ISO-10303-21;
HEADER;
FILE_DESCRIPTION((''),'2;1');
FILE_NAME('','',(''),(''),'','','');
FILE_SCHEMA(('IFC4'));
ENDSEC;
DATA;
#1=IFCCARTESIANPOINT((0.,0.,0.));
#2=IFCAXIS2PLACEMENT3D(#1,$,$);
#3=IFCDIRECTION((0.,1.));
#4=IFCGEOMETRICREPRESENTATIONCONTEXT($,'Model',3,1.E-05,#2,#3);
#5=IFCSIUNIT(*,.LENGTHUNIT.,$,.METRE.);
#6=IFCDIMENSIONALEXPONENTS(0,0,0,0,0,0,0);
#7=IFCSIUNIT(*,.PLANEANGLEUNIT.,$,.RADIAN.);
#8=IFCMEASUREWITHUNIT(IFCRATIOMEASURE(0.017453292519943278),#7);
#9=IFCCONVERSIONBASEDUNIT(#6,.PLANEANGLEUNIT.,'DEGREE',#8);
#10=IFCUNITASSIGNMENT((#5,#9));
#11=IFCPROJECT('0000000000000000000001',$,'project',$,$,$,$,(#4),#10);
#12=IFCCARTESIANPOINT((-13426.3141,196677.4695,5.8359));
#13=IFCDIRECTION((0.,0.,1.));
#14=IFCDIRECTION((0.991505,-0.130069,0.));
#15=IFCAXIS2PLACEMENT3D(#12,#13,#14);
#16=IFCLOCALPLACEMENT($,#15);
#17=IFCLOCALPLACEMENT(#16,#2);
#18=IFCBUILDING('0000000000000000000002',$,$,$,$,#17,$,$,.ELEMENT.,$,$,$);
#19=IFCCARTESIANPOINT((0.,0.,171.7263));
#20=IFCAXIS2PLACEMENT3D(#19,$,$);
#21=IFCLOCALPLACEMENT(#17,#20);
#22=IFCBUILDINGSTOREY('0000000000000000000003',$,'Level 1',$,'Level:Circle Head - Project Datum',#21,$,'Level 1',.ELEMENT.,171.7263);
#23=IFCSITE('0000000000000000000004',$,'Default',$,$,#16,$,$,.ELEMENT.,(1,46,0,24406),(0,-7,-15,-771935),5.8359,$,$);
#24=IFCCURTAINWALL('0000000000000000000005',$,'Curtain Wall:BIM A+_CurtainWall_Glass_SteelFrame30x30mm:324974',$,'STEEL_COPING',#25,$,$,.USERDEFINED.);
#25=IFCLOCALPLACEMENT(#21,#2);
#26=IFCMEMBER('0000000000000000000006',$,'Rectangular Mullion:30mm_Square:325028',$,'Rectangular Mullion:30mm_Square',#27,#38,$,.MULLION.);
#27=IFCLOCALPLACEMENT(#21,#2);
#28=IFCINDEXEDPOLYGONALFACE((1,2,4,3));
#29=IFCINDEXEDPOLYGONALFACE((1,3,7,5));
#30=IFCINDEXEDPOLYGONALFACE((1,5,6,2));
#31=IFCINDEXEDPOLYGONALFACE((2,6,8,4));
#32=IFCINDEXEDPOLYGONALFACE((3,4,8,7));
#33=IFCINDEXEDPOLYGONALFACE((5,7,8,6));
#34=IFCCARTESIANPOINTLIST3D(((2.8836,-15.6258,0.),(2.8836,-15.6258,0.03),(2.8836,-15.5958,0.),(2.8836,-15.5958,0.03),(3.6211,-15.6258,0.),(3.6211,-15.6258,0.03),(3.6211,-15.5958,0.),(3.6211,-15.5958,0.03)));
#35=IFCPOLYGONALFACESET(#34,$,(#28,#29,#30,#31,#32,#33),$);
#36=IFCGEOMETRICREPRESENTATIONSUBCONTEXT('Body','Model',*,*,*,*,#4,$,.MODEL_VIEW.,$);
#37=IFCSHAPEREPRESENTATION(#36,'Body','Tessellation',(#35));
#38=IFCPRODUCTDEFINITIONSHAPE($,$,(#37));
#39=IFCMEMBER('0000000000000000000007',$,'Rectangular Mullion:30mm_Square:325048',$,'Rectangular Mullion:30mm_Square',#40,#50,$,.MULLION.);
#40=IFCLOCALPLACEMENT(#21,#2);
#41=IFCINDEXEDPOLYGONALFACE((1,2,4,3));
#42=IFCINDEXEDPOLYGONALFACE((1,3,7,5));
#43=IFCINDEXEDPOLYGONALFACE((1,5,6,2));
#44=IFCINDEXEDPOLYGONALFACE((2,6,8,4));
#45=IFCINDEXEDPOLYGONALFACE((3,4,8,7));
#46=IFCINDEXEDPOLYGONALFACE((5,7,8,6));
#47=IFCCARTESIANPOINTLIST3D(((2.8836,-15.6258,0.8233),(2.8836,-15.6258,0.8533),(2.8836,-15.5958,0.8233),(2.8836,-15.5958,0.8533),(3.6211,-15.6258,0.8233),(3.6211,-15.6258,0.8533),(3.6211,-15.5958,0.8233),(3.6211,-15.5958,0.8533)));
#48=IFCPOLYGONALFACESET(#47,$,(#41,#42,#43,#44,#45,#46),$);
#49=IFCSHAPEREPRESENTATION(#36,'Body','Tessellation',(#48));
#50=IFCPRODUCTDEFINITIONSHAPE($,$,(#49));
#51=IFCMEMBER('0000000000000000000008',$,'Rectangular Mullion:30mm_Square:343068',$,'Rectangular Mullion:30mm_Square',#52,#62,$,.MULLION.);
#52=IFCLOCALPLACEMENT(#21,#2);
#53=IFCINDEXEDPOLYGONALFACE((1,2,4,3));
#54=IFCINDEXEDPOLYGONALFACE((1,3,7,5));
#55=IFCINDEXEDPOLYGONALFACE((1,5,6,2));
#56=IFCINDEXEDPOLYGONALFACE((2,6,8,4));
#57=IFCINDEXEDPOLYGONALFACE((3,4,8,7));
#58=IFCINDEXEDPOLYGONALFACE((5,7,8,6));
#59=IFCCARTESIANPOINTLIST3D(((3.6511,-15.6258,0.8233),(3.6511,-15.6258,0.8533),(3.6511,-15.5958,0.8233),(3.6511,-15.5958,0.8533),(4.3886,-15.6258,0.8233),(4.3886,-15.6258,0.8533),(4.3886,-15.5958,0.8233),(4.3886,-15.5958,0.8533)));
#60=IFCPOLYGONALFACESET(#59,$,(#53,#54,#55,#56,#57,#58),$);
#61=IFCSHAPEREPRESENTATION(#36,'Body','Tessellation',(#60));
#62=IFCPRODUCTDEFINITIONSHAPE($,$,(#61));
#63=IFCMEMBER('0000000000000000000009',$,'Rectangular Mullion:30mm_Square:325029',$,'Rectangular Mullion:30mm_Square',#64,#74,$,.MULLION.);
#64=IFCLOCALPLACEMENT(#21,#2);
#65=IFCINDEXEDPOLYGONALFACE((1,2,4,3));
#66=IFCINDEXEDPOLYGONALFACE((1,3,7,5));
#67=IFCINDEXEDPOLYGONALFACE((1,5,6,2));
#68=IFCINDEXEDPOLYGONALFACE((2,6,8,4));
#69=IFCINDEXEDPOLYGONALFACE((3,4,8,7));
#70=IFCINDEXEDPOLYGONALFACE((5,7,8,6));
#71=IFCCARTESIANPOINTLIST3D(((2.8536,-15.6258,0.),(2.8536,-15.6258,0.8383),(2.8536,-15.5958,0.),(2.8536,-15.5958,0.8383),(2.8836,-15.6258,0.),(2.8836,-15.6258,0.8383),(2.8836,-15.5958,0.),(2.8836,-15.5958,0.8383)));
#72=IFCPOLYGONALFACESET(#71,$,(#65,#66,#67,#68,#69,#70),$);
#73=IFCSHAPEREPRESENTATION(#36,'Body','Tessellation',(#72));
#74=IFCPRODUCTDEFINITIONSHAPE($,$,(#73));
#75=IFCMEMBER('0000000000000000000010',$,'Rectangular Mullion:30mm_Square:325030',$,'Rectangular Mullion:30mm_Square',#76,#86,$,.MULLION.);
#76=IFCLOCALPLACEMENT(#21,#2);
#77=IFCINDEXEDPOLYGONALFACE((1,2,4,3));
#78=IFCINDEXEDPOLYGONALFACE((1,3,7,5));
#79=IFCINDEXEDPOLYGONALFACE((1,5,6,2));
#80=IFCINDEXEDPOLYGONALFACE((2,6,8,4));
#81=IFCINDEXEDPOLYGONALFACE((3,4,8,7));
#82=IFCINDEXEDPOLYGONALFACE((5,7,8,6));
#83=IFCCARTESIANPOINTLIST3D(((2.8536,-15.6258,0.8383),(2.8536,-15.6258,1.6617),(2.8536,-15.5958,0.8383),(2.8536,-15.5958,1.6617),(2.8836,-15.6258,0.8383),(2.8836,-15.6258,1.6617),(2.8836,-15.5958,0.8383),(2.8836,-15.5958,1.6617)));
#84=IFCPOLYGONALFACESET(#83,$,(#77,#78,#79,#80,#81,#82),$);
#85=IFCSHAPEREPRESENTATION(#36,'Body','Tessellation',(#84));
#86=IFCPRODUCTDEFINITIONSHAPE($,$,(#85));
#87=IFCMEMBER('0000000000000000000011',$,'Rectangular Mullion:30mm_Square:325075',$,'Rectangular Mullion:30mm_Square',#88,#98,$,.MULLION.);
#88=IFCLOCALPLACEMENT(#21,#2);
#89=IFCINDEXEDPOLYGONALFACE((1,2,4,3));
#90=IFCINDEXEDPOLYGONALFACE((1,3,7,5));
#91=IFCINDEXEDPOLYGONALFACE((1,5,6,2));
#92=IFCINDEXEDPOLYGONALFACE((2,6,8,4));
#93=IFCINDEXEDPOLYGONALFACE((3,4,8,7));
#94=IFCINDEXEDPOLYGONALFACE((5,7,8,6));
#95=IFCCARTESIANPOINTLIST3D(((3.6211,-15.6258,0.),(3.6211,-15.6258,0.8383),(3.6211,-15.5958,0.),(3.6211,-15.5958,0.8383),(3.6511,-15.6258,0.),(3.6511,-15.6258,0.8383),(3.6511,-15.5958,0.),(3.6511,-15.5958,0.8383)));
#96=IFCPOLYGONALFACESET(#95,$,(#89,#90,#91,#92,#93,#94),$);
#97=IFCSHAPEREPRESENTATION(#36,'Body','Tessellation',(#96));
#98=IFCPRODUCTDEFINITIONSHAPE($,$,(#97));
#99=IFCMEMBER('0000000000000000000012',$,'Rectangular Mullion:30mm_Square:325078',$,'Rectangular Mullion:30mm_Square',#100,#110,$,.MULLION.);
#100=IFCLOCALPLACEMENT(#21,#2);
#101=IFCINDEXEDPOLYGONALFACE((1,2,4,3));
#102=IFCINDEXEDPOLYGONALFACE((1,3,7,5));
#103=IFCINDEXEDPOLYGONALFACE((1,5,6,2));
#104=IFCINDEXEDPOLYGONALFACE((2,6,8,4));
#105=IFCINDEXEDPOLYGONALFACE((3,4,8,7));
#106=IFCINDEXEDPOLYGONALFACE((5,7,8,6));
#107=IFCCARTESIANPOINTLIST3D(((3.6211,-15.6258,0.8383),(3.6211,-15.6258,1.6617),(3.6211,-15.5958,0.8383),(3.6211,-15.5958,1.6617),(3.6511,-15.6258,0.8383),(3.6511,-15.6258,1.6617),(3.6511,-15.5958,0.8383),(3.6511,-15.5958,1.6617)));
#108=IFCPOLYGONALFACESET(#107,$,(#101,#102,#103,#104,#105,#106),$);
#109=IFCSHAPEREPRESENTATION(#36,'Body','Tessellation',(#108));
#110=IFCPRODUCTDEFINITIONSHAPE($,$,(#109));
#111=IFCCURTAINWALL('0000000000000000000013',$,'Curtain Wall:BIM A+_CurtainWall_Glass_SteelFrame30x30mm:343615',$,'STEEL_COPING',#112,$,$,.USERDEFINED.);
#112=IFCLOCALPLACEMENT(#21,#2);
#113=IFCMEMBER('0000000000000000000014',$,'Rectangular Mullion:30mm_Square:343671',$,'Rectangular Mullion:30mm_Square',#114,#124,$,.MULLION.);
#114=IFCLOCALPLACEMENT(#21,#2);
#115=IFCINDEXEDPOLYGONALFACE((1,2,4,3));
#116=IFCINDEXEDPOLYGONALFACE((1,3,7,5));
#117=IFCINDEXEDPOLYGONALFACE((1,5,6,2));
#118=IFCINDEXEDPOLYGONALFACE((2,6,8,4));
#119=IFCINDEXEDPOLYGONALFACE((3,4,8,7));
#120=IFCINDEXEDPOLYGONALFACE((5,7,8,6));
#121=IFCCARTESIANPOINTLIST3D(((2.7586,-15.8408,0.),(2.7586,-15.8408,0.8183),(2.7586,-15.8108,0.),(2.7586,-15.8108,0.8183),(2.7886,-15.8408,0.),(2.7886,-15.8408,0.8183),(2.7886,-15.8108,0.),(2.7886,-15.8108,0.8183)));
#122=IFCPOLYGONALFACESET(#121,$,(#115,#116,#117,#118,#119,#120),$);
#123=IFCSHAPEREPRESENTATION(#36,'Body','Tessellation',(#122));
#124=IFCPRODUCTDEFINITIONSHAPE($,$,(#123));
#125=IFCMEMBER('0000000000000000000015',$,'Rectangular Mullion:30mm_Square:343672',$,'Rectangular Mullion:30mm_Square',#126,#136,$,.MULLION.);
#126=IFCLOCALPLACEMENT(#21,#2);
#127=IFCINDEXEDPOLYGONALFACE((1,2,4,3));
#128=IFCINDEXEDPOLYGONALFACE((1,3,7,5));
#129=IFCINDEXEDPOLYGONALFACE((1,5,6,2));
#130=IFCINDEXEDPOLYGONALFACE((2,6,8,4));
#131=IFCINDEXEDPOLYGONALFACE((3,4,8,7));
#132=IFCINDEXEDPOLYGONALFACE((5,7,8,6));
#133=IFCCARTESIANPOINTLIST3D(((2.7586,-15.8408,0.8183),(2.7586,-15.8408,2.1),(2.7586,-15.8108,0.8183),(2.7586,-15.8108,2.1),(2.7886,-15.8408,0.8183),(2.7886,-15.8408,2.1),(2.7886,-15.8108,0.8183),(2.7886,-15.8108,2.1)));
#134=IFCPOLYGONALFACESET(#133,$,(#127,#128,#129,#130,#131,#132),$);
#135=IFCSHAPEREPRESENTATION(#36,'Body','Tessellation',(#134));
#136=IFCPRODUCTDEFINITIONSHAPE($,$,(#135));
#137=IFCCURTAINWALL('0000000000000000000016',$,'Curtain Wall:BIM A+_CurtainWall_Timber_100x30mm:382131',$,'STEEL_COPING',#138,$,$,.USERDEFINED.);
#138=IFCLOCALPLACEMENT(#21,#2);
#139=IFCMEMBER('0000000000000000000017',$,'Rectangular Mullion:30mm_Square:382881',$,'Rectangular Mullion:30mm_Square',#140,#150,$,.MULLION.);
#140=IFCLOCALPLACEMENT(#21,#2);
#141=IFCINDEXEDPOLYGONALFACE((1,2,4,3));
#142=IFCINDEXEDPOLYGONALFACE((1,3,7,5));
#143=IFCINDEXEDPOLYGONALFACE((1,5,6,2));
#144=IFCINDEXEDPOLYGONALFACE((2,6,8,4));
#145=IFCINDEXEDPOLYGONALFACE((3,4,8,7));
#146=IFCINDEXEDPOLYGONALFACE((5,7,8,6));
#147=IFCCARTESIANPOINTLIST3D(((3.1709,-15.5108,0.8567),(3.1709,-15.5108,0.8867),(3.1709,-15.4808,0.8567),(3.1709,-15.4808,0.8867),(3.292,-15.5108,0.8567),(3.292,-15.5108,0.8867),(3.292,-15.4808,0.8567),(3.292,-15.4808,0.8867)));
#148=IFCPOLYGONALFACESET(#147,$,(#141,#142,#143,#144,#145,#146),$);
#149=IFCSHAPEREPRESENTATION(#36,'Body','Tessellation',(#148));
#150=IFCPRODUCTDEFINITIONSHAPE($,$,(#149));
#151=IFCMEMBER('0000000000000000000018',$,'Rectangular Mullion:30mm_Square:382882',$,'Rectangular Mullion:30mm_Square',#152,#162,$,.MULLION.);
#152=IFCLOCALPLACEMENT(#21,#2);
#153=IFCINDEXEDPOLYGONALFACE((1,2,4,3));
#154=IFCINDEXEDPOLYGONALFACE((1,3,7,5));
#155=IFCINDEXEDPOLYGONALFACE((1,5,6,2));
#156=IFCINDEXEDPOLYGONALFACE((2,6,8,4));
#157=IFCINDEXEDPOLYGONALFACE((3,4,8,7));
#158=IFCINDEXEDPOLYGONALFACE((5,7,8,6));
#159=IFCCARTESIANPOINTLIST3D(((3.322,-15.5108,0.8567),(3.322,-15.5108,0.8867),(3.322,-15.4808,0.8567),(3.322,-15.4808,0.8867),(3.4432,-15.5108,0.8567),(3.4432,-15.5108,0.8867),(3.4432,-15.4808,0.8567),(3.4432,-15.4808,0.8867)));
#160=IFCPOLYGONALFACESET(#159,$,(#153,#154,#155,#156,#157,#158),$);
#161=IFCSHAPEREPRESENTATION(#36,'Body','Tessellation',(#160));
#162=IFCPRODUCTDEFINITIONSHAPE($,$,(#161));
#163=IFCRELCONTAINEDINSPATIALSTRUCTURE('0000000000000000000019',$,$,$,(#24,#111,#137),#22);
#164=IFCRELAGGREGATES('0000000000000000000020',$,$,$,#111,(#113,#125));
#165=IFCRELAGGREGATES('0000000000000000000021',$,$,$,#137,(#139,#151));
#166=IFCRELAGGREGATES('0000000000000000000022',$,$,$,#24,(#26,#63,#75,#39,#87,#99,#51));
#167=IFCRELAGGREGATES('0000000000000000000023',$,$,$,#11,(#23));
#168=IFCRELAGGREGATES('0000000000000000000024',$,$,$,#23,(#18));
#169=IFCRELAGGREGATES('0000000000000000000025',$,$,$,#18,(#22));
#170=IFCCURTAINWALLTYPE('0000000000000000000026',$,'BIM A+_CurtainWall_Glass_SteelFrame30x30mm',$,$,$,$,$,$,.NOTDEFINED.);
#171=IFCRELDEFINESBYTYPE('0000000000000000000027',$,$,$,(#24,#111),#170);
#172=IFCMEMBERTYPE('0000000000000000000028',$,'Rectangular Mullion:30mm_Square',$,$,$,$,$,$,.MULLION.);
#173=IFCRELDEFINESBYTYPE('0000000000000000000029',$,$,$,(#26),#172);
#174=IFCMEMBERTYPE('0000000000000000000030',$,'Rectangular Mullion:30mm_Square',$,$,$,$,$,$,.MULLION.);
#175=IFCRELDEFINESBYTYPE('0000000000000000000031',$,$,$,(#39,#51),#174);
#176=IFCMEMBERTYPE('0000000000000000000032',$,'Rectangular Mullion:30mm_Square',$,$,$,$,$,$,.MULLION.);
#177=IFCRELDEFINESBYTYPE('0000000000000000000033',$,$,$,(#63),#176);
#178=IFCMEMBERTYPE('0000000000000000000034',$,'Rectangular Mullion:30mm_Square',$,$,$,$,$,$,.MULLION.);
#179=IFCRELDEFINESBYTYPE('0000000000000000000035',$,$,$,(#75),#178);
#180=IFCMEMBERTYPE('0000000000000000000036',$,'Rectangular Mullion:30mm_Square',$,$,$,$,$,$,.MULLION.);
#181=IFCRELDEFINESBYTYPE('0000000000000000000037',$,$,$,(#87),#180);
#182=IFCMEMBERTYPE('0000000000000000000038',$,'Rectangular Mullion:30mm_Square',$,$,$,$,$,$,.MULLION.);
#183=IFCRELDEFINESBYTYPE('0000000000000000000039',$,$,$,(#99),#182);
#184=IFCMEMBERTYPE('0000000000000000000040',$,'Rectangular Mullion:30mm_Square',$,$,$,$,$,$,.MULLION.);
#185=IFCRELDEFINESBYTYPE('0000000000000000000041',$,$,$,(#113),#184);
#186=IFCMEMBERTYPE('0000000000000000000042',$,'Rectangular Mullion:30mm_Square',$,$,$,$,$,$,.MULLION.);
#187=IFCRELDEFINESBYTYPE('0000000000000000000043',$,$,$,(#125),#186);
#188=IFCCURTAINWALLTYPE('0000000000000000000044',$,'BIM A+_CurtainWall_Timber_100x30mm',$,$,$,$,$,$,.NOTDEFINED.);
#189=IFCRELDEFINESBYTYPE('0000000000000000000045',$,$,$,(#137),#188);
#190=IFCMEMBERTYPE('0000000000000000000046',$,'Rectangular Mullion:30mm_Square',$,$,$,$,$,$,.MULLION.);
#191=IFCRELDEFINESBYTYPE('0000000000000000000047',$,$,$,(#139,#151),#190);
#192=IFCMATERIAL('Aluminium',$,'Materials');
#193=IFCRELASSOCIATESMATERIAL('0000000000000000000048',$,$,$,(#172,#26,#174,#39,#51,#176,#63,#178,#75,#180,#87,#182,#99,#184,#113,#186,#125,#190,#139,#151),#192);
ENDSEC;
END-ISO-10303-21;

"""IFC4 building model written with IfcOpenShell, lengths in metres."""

from ifc_helpers import new_model, entity, si_unit, converted_unit, direction, frame, origin, place, context, subcontext, project, spatial, indexed_curve, outline, extrude, source, transform, mapped, material, type_object, type_shapes, element, aggregate, save


model = new_model("IFC4")

# Units and contexts
model_context = context("Model", 3, precision=1e-05, world=origin(), true_north=direction((0.0, 1.0)))
body_context = subcontext(model_context, "Body", "Model", "MODEL_VIEW")
ifc_project = project(units=[si_unit("LENGTHUNIT", "METRE"), converted_unit("PLANEANGLEUNIT", "DEGREE", entity("IfcRatioMeasure", 0.017453292519943278), si_unit("PLANEANGLEUNIT", "RADIAN"), dimensions=[0, 0, 0, 0, 0, 0, 0])], contexts=[model_context])

# Site, building, storey
site_placement = place(None, frame((-13426.3141, 196677.4695, 5.8359), z_axis=(0.0, 0.0, 1.0), x_axis=(0.991505, -0.130069, 0.0)))
site = spatial("IfcSite", under=ifc_project, at=site_placement, Name="Default", CompositionType="ELEMENT", RefLatitude=(1, 46, 0, 24406), RefLongitude=(0, -7, -15, -771935), RefElevation=5.8359)
building_placement = place(site_placement, origin())
building = spatial("IfcBuilding", under=site, at=building_placement, CompositionType="ELEMENT")
storey_placement = place(building_placement, frame((0.0, 0.0, 171.7263)))
storey = spatial("IfcBuildingStorey", under=building, at=storey_placement, Name="Level 1", ObjectType="Level:Circle Head - Project Datum", LongName="Level 1", CompositionType="ELEMENT", Elevation=171.7263)

# Curtain walls, members
curtain_wall_type_1 = type_object("IfcCurtainWallType", Name="BIM A+_CurtainWall_Glass_SteelFrame30x30mm", PredefinedType="NOTDEFINED")
curtain_wall_1_placement = place(storey_placement, frame((0.0, 0.0, -171.7263)))
curtain_wall_1 = element("IfcCurtainWall", 1, at=curtain_wall_1_placement, inside=storey, type_object=curtain_wall_type_1, Name="Curtain Wall:BIM A+_CurtainWall_Glass_SteelFrame30x30mm:324974", ObjectType="STEEL_COPING", PredefinedType="USERDEFINED")
ifc_material_1 = material(Name="Aluminium", Category="Materials")
member_type_1 = type_object("IfcMemberType", Name="Rectangular Mullion:30mm_Square", PredefinedType="MULLION", material=ifc_material_1)
shared_shape_1 = source(origin(), body_context, "Body", "SweptSolid", [
    extrude(outline(indexed_curve([(-0.015, -0.015), (0.015, -0.015), (0.015, 0.015), (-0.015, 0.015), (-0.015, -0.015)], self_intersect=False)), frame((-0.015, 0.0, -0.7375), z_axis=(0.0, 0.0, 1.0), x_axis=(0.0, -1.0, 0.0)), (0.0, 0.0, 1.0), 0.7375),
])
type_shapes(member_type_1, [shared_shape_1])
member_1_placement = place(curtain_wall_1_placement, frame((3.6211, -15.6108, 171.7263), z_axis=(1.0, 0.0, 0.0), x_axis=(0.0, 0.0, -1.0)))
member_1 = element("IfcMember", 2, at=member_1_placement, type_object=member_type_1, material=ifc_material_1, Name="Rectangular Mullion:30mm_Square:325028", ObjectType="Rectangular Mullion:30mm_Square", PredefinedType="MULLION", context=body_context, shape_type="MappedRepresentation", body=[
    mapped(shared_shape_1, transform((0.0, 0.0, 0.0), scale=1.0)),
])
member_type_2 = type_object("IfcMemberType", Name="Rectangular Mullion:30mm_Square", PredefinedType="MULLION", material=ifc_material_1)
shared_shape_2 = source(origin(), body_context, "Body", "SweptSolid", [
    extrude(outline(indexed_curve([(-0.015, -0.015), (0.015, -0.015), (0.015, 0.015), (-0.015, 0.015), (-0.015, -0.015)], self_intersect=False)), frame((0.0, 0.0, -0.7375), z_axis=(0.0, 0.0, 1.0), x_axis=(0.0, -1.0, 0.0)), (0.0, 0.0, 1.0), 0.7375),
])
type_shapes(member_type_2, [shared_shape_2])
member_2_placement = place(curtain_wall_1_placement, frame((2.8836, -15.6108, 172.5646), z_axis=(-1.0, 0.0, 0.0), x_axis=(0.0, 0.0, 1.0)))
member_2 = element("IfcMember", 3, at=member_2_placement, type_object=member_type_2, material=ifc_material_1, Name="Rectangular Mullion:30mm_Square:325048", ObjectType="Rectangular Mullion:30mm_Square", PredefinedType="MULLION", context=body_context, shape_type="MappedRepresentation", body=[
    mapped(shared_shape_2, transform((0.0, 0.0, 0.0), scale=1.0)),
])
member_3_placement = place(curtain_wall_1_placement, frame((3.6511, -15.6108, 172.5646), z_axis=(-1.0, 0.0, 0.0), x_axis=(0.0, 0.0, 1.0)))
member_3 = element("IfcMember", 4, at=member_3_placement, type_object=member_type_2, material=ifc_material_1, Name="Rectangular Mullion:30mm_Square:343068", ObjectType="Rectangular Mullion:30mm_Square", PredefinedType="MULLION", context=body_context, shape_type="MappedRepresentation", body=[
    mapped(shared_shape_2, transform((0.0, 0.0, 0.0), scale=1.0)),
])
member_type_3 = type_object("IfcMemberType", Name="Rectangular Mullion:30mm_Square", PredefinedType="MULLION", material=ifc_material_1)
shared_shape_3 = source(origin(), body_context, "Body", "SweptSolid", [
    extrude(outline(indexed_curve([(-0.015, -0.015), (0.015, -0.015), (0.015, 0.015), (-0.015, 0.015), (-0.015, -0.015)], self_intersect=False)), frame((-0.015, 0.0, -0.8383), z_axis=(0.0, 0.0, 1.0), x_axis=(0.0, -1.0, 0.0)), (0.0, 0.0, 1.0), 0.8383),
])
type_shapes(member_type_3, [shared_shape_3])
member_4_placement = place(curtain_wall_1_placement, frame((2.8536, -15.6108, 171.7263), z_axis=(0.0, 0.0, -1.0), x_axis=(-1.0, 0.0, 0.0)))
member_4 = element("IfcMember", 5, at=member_4_placement, type_object=member_type_3, material=ifc_material_1, Name="Rectangular Mullion:30mm_Square:325029", ObjectType="Rectangular Mullion:30mm_Square", PredefinedType="MULLION", context=body_context, shape_type="MappedRepresentation", body=[
    mapped(shared_shape_3, transform((0.0, 0.0, 0.0), scale=1.0)),
])
member_type_4 = type_object("IfcMemberType", Name="Rectangular Mullion:30mm_Square", PredefinedType="MULLION", material=ifc_material_1)
shared_shape_4 = source(origin(), body_context, "Body", "SweptSolid", [
    extrude(outline(indexed_curve([(-0.015, -0.015), (0.015, -0.015), (0.015, 0.015), (-0.015, 0.015), (-0.015, -0.015)], self_intersect=False)), frame((-0.015, 0.0, -0.8233), z_axis=(0.0, 0.0, 1.0), x_axis=(0.0, -1.0, 0.0)), (0.0, 0.0, 1.0), 0.8233),
])
type_shapes(member_type_4, [shared_shape_4])
member_5_placement = place(curtain_wall_1_placement, frame((2.8536, -15.6108, 172.5646), z_axis=(0.0, 0.0, -1.0), x_axis=(-1.0, 0.0, 0.0)))
member_5 = element("IfcMember", 6, at=member_5_placement, type_object=member_type_4, material=ifc_material_1, Name="Rectangular Mullion:30mm_Square:325030", ObjectType="Rectangular Mullion:30mm_Square", PredefinedType="MULLION", context=body_context, shape_type="MappedRepresentation", body=[
    mapped(shared_shape_4, transform((0.0, 0.0, 0.0), scale=1.0)),
])
member_type_5 = type_object("IfcMemberType", Name="Rectangular Mullion:30mm_Square", PredefinedType="MULLION", material=ifc_material_1)
shared_shape_5 = source(origin(), body_context, "Body", "SweptSolid", [
    extrude(outline(indexed_curve([(-0.015, -0.015), (0.015, -0.015), (0.015, 0.015), (-0.015, 0.015), (-0.015, -0.015)], self_intersect=False)), frame((0.0, 0.0, -0.8383), z_axis=(0.0, 0.0, 1.0), x_axis=(0.0, -1.0, 0.0)), (0.0, 0.0, 1.0), 0.8383),
])
type_shapes(member_type_5, [shared_shape_5])
member_6_placement = place(curtain_wall_1_placement, frame((3.6361, -15.6108, 171.7263), z_axis=(0.0, 0.0, -1.0), x_axis=(-1.0, 0.0, 0.0)))
member_6 = element("IfcMember", 7, at=member_6_placement, type_object=member_type_5, material=ifc_material_1, Name="Rectangular Mullion:30mm_Square:325075", ObjectType="Rectangular Mullion:30mm_Square", PredefinedType="MULLION", context=body_context, shape_type="MappedRepresentation", body=[
    mapped(shared_shape_5, transform((0.0, 0.0, 0.0), scale=1.0)),
])
member_type_6 = type_object("IfcMemberType", Name="Rectangular Mullion:30mm_Square", PredefinedType="MULLION", material=ifc_material_1)
shared_shape_6 = source(origin(), body_context, "Body", "SweptSolid", [
    extrude(outline(indexed_curve([(-0.015, -0.015), (0.015, -0.015), (0.015, 0.015), (-0.015, 0.015), (-0.015, -0.015)], self_intersect=False)), frame((0.0, 0.0, -0.8233), z_axis=(0.0, 0.0, 1.0), x_axis=(0.0, -1.0, 0.0)), (0.0, 0.0, 1.0), 0.8233),
])
type_shapes(member_type_6, [shared_shape_6])
member_7_placement = place(curtain_wall_1_placement, frame((3.6361, -15.6108, 172.5646), z_axis=(0.0, 0.0, -1.0), x_axis=(-1.0, 0.0, 0.0)))
member_7 = element("IfcMember", 8, at=member_7_placement, type_object=member_type_6, material=ifc_material_1, Name="Rectangular Mullion:30mm_Square:325078", ObjectType="Rectangular Mullion:30mm_Square", PredefinedType="MULLION", context=body_context, shape_type="MappedRepresentation", body=[
    mapped(shared_shape_6, transform((0.0, 0.0, 0.0), scale=1.0)),
])
curtain_wall_2_placement = place(storey_placement, frame((0.0, 0.0, -171.7263)))
curtain_wall_2 = element("IfcCurtainWall", 9, at=curtain_wall_2_placement, inside=storey, type_object=curtain_wall_type_1, Name="Curtain Wall:BIM A+_CurtainWall_Glass_SteelFrame30x30mm:343615", ObjectType="STEEL_COPING", PredefinedType="USERDEFINED")
member_type_7 = type_object("IfcMemberType", Name="Rectangular Mullion:30mm_Square", PredefinedType="MULLION", material=ifc_material_1)
shared_shape_7 = source(origin(), body_context, "Body", "SweptSolid", [
    extrude(outline(indexed_curve([(-0.015, -0.015), (0.015, -0.015), (0.015, 0.015), (-0.015, 0.015), (-0.015, -0.015)], self_intersect=False)), frame((-0.015, 0.0, -0.8183), z_axis=(0.0, 0.0, 1.0), x_axis=(0.0, -1.0, 0.0)), (0.0, 0.0, 1.0), 0.8183),
])
type_shapes(member_type_7, [shared_shape_7])
member_8_placement = place(curtain_wall_2_placement, frame((2.7736, -15.8108, 171.7263), z_axis=(0.0, 0.0, -1.0), x_axis=(0.0, 1.0, 0.0)))
member_8 = element("IfcMember", 10, at=member_8_placement, type_object=member_type_7, material=ifc_material_1, Name="Rectangular Mullion:30mm_Square:343671", ObjectType="Rectangular Mullion:30mm_Square", PredefinedType="MULLION", context=body_context, shape_type="MappedRepresentation", body=[
    mapped(shared_shape_7, transform((0.0, 0.0, 0.0), scale=1.0)),
])
member_type_8 = type_object("IfcMemberType", Name="Rectangular Mullion:30mm_Square", PredefinedType="MULLION", material=ifc_material_1)
shared_shape_8 = source(origin(), body_context, "Body", "SweptSolid", [
    extrude(outline(indexed_curve([(-0.015, -0.015), (0.015, -0.015), (0.015, 0.015), (-0.015, 0.015), (-0.015, -0.015)], self_intersect=False)), frame((-0.015, 0.0, -1.2817), z_axis=(0.0, 0.0, 1.0), x_axis=(0.0, -1.0, 0.0)), (0.0, 0.0, 1.0), 1.2817),
])
type_shapes(member_type_8, [shared_shape_8])
member_9_placement = place(curtain_wall_2_placement, frame((2.7736, -15.8108, 172.5446), z_axis=(0.0, 0.0, -1.0), x_axis=(0.0, 1.0, 0.0)))
member_9 = element("IfcMember", 11, at=member_9_placement, type_object=member_type_8, material=ifc_material_1, Name="Rectangular Mullion:30mm_Square:343672", ObjectType="Rectangular Mullion:30mm_Square", PredefinedType="MULLION", context=body_context, shape_type="MappedRepresentation", body=[
    mapped(shared_shape_8, transform((0.0, 0.0, 0.0), scale=1.0)),
])
aggregate(curtain_wall_2, [member_8, member_9])
curtain_wall_type_2 = type_object("IfcCurtainWallType", Name="BIM A+_CurtainWall_Timber_100x30mm", PredefinedType="NOTDEFINED")
curtain_wall_3_placement = place(storey_placement, frame((0.0, 0.0, -171.7263)))
curtain_wall_3 = element("IfcCurtainWall", 12, at=curtain_wall_3_placement, inside=storey, type_object=curtain_wall_type_2, Name="Curtain Wall:BIM A+_CurtainWall_Timber_100x30mm:382131", ObjectType="STEEL_COPING", PredefinedType="USERDEFINED")
member_type_9 = type_object("IfcMemberType", Name="Rectangular Mullion:30mm_Square", PredefinedType="MULLION", material=ifc_material_1)
shared_shape_9 = source(origin(), body_context, "Body", "SweptSolid", [
    extrude(outline(indexed_curve([(-0.015, -0.015), (0.015, -0.015), (0.015, 0.015), (-0.015, 0.015), (-0.015, -0.015)], self_intersect=False)), frame((0.0, 0.0, -0.1212), z_axis=(0.0, 0.0, 1.0), x_axis=(0.0, -1.0, 0.0)), (0.0, 0.0, 1.0), 0.1212),
])
type_shapes(member_type_9, [shared_shape_9])
member_10_placement = place(curtain_wall_3_placement, frame((3.292, -15.4958, 172.598), z_axis=(1.0, 0.0, 0.0), x_axis=(0.0, 0.0, 1.0)))
member_10 = element("IfcMember", 13, at=member_10_placement, type_object=member_type_9, material=ifc_material_1, Name="Rectangular Mullion:30mm_Square:382881", ObjectType="Rectangular Mullion:30mm_Square", PredefinedType="MULLION", context=body_context, shape_type="MappedRepresentation", body=[
    mapped(shared_shape_9, transform((0.0, 0.0, 0.0), scale=1.0)),
])
member_11_placement = place(curtain_wall_3_placement, frame((3.4432, -15.4958, 172.598), z_axis=(1.0, 0.0, 0.0), x_axis=(0.0, 0.0, 1.0)))
member_11 = element("IfcMember", 14, at=member_11_placement, type_object=member_type_9, material=ifc_material_1, Name="Rectangular Mullion:30mm_Square:382882", ObjectType="Rectangular Mullion:30mm_Square", PredefinedType="MULLION", context=body_context, shape_type="MappedRepresentation", body=[
    mapped(shared_shape_9, transform((0.0, 0.0, 0.0), scale=1.0)),
])
aggregate(curtain_wall_3, [member_10, member_11])

aggregate(curtain_wall_1, [member_1, member_4, member_5, member_2, member_6, member_7, member_3])

save(model, "model.ifc")
